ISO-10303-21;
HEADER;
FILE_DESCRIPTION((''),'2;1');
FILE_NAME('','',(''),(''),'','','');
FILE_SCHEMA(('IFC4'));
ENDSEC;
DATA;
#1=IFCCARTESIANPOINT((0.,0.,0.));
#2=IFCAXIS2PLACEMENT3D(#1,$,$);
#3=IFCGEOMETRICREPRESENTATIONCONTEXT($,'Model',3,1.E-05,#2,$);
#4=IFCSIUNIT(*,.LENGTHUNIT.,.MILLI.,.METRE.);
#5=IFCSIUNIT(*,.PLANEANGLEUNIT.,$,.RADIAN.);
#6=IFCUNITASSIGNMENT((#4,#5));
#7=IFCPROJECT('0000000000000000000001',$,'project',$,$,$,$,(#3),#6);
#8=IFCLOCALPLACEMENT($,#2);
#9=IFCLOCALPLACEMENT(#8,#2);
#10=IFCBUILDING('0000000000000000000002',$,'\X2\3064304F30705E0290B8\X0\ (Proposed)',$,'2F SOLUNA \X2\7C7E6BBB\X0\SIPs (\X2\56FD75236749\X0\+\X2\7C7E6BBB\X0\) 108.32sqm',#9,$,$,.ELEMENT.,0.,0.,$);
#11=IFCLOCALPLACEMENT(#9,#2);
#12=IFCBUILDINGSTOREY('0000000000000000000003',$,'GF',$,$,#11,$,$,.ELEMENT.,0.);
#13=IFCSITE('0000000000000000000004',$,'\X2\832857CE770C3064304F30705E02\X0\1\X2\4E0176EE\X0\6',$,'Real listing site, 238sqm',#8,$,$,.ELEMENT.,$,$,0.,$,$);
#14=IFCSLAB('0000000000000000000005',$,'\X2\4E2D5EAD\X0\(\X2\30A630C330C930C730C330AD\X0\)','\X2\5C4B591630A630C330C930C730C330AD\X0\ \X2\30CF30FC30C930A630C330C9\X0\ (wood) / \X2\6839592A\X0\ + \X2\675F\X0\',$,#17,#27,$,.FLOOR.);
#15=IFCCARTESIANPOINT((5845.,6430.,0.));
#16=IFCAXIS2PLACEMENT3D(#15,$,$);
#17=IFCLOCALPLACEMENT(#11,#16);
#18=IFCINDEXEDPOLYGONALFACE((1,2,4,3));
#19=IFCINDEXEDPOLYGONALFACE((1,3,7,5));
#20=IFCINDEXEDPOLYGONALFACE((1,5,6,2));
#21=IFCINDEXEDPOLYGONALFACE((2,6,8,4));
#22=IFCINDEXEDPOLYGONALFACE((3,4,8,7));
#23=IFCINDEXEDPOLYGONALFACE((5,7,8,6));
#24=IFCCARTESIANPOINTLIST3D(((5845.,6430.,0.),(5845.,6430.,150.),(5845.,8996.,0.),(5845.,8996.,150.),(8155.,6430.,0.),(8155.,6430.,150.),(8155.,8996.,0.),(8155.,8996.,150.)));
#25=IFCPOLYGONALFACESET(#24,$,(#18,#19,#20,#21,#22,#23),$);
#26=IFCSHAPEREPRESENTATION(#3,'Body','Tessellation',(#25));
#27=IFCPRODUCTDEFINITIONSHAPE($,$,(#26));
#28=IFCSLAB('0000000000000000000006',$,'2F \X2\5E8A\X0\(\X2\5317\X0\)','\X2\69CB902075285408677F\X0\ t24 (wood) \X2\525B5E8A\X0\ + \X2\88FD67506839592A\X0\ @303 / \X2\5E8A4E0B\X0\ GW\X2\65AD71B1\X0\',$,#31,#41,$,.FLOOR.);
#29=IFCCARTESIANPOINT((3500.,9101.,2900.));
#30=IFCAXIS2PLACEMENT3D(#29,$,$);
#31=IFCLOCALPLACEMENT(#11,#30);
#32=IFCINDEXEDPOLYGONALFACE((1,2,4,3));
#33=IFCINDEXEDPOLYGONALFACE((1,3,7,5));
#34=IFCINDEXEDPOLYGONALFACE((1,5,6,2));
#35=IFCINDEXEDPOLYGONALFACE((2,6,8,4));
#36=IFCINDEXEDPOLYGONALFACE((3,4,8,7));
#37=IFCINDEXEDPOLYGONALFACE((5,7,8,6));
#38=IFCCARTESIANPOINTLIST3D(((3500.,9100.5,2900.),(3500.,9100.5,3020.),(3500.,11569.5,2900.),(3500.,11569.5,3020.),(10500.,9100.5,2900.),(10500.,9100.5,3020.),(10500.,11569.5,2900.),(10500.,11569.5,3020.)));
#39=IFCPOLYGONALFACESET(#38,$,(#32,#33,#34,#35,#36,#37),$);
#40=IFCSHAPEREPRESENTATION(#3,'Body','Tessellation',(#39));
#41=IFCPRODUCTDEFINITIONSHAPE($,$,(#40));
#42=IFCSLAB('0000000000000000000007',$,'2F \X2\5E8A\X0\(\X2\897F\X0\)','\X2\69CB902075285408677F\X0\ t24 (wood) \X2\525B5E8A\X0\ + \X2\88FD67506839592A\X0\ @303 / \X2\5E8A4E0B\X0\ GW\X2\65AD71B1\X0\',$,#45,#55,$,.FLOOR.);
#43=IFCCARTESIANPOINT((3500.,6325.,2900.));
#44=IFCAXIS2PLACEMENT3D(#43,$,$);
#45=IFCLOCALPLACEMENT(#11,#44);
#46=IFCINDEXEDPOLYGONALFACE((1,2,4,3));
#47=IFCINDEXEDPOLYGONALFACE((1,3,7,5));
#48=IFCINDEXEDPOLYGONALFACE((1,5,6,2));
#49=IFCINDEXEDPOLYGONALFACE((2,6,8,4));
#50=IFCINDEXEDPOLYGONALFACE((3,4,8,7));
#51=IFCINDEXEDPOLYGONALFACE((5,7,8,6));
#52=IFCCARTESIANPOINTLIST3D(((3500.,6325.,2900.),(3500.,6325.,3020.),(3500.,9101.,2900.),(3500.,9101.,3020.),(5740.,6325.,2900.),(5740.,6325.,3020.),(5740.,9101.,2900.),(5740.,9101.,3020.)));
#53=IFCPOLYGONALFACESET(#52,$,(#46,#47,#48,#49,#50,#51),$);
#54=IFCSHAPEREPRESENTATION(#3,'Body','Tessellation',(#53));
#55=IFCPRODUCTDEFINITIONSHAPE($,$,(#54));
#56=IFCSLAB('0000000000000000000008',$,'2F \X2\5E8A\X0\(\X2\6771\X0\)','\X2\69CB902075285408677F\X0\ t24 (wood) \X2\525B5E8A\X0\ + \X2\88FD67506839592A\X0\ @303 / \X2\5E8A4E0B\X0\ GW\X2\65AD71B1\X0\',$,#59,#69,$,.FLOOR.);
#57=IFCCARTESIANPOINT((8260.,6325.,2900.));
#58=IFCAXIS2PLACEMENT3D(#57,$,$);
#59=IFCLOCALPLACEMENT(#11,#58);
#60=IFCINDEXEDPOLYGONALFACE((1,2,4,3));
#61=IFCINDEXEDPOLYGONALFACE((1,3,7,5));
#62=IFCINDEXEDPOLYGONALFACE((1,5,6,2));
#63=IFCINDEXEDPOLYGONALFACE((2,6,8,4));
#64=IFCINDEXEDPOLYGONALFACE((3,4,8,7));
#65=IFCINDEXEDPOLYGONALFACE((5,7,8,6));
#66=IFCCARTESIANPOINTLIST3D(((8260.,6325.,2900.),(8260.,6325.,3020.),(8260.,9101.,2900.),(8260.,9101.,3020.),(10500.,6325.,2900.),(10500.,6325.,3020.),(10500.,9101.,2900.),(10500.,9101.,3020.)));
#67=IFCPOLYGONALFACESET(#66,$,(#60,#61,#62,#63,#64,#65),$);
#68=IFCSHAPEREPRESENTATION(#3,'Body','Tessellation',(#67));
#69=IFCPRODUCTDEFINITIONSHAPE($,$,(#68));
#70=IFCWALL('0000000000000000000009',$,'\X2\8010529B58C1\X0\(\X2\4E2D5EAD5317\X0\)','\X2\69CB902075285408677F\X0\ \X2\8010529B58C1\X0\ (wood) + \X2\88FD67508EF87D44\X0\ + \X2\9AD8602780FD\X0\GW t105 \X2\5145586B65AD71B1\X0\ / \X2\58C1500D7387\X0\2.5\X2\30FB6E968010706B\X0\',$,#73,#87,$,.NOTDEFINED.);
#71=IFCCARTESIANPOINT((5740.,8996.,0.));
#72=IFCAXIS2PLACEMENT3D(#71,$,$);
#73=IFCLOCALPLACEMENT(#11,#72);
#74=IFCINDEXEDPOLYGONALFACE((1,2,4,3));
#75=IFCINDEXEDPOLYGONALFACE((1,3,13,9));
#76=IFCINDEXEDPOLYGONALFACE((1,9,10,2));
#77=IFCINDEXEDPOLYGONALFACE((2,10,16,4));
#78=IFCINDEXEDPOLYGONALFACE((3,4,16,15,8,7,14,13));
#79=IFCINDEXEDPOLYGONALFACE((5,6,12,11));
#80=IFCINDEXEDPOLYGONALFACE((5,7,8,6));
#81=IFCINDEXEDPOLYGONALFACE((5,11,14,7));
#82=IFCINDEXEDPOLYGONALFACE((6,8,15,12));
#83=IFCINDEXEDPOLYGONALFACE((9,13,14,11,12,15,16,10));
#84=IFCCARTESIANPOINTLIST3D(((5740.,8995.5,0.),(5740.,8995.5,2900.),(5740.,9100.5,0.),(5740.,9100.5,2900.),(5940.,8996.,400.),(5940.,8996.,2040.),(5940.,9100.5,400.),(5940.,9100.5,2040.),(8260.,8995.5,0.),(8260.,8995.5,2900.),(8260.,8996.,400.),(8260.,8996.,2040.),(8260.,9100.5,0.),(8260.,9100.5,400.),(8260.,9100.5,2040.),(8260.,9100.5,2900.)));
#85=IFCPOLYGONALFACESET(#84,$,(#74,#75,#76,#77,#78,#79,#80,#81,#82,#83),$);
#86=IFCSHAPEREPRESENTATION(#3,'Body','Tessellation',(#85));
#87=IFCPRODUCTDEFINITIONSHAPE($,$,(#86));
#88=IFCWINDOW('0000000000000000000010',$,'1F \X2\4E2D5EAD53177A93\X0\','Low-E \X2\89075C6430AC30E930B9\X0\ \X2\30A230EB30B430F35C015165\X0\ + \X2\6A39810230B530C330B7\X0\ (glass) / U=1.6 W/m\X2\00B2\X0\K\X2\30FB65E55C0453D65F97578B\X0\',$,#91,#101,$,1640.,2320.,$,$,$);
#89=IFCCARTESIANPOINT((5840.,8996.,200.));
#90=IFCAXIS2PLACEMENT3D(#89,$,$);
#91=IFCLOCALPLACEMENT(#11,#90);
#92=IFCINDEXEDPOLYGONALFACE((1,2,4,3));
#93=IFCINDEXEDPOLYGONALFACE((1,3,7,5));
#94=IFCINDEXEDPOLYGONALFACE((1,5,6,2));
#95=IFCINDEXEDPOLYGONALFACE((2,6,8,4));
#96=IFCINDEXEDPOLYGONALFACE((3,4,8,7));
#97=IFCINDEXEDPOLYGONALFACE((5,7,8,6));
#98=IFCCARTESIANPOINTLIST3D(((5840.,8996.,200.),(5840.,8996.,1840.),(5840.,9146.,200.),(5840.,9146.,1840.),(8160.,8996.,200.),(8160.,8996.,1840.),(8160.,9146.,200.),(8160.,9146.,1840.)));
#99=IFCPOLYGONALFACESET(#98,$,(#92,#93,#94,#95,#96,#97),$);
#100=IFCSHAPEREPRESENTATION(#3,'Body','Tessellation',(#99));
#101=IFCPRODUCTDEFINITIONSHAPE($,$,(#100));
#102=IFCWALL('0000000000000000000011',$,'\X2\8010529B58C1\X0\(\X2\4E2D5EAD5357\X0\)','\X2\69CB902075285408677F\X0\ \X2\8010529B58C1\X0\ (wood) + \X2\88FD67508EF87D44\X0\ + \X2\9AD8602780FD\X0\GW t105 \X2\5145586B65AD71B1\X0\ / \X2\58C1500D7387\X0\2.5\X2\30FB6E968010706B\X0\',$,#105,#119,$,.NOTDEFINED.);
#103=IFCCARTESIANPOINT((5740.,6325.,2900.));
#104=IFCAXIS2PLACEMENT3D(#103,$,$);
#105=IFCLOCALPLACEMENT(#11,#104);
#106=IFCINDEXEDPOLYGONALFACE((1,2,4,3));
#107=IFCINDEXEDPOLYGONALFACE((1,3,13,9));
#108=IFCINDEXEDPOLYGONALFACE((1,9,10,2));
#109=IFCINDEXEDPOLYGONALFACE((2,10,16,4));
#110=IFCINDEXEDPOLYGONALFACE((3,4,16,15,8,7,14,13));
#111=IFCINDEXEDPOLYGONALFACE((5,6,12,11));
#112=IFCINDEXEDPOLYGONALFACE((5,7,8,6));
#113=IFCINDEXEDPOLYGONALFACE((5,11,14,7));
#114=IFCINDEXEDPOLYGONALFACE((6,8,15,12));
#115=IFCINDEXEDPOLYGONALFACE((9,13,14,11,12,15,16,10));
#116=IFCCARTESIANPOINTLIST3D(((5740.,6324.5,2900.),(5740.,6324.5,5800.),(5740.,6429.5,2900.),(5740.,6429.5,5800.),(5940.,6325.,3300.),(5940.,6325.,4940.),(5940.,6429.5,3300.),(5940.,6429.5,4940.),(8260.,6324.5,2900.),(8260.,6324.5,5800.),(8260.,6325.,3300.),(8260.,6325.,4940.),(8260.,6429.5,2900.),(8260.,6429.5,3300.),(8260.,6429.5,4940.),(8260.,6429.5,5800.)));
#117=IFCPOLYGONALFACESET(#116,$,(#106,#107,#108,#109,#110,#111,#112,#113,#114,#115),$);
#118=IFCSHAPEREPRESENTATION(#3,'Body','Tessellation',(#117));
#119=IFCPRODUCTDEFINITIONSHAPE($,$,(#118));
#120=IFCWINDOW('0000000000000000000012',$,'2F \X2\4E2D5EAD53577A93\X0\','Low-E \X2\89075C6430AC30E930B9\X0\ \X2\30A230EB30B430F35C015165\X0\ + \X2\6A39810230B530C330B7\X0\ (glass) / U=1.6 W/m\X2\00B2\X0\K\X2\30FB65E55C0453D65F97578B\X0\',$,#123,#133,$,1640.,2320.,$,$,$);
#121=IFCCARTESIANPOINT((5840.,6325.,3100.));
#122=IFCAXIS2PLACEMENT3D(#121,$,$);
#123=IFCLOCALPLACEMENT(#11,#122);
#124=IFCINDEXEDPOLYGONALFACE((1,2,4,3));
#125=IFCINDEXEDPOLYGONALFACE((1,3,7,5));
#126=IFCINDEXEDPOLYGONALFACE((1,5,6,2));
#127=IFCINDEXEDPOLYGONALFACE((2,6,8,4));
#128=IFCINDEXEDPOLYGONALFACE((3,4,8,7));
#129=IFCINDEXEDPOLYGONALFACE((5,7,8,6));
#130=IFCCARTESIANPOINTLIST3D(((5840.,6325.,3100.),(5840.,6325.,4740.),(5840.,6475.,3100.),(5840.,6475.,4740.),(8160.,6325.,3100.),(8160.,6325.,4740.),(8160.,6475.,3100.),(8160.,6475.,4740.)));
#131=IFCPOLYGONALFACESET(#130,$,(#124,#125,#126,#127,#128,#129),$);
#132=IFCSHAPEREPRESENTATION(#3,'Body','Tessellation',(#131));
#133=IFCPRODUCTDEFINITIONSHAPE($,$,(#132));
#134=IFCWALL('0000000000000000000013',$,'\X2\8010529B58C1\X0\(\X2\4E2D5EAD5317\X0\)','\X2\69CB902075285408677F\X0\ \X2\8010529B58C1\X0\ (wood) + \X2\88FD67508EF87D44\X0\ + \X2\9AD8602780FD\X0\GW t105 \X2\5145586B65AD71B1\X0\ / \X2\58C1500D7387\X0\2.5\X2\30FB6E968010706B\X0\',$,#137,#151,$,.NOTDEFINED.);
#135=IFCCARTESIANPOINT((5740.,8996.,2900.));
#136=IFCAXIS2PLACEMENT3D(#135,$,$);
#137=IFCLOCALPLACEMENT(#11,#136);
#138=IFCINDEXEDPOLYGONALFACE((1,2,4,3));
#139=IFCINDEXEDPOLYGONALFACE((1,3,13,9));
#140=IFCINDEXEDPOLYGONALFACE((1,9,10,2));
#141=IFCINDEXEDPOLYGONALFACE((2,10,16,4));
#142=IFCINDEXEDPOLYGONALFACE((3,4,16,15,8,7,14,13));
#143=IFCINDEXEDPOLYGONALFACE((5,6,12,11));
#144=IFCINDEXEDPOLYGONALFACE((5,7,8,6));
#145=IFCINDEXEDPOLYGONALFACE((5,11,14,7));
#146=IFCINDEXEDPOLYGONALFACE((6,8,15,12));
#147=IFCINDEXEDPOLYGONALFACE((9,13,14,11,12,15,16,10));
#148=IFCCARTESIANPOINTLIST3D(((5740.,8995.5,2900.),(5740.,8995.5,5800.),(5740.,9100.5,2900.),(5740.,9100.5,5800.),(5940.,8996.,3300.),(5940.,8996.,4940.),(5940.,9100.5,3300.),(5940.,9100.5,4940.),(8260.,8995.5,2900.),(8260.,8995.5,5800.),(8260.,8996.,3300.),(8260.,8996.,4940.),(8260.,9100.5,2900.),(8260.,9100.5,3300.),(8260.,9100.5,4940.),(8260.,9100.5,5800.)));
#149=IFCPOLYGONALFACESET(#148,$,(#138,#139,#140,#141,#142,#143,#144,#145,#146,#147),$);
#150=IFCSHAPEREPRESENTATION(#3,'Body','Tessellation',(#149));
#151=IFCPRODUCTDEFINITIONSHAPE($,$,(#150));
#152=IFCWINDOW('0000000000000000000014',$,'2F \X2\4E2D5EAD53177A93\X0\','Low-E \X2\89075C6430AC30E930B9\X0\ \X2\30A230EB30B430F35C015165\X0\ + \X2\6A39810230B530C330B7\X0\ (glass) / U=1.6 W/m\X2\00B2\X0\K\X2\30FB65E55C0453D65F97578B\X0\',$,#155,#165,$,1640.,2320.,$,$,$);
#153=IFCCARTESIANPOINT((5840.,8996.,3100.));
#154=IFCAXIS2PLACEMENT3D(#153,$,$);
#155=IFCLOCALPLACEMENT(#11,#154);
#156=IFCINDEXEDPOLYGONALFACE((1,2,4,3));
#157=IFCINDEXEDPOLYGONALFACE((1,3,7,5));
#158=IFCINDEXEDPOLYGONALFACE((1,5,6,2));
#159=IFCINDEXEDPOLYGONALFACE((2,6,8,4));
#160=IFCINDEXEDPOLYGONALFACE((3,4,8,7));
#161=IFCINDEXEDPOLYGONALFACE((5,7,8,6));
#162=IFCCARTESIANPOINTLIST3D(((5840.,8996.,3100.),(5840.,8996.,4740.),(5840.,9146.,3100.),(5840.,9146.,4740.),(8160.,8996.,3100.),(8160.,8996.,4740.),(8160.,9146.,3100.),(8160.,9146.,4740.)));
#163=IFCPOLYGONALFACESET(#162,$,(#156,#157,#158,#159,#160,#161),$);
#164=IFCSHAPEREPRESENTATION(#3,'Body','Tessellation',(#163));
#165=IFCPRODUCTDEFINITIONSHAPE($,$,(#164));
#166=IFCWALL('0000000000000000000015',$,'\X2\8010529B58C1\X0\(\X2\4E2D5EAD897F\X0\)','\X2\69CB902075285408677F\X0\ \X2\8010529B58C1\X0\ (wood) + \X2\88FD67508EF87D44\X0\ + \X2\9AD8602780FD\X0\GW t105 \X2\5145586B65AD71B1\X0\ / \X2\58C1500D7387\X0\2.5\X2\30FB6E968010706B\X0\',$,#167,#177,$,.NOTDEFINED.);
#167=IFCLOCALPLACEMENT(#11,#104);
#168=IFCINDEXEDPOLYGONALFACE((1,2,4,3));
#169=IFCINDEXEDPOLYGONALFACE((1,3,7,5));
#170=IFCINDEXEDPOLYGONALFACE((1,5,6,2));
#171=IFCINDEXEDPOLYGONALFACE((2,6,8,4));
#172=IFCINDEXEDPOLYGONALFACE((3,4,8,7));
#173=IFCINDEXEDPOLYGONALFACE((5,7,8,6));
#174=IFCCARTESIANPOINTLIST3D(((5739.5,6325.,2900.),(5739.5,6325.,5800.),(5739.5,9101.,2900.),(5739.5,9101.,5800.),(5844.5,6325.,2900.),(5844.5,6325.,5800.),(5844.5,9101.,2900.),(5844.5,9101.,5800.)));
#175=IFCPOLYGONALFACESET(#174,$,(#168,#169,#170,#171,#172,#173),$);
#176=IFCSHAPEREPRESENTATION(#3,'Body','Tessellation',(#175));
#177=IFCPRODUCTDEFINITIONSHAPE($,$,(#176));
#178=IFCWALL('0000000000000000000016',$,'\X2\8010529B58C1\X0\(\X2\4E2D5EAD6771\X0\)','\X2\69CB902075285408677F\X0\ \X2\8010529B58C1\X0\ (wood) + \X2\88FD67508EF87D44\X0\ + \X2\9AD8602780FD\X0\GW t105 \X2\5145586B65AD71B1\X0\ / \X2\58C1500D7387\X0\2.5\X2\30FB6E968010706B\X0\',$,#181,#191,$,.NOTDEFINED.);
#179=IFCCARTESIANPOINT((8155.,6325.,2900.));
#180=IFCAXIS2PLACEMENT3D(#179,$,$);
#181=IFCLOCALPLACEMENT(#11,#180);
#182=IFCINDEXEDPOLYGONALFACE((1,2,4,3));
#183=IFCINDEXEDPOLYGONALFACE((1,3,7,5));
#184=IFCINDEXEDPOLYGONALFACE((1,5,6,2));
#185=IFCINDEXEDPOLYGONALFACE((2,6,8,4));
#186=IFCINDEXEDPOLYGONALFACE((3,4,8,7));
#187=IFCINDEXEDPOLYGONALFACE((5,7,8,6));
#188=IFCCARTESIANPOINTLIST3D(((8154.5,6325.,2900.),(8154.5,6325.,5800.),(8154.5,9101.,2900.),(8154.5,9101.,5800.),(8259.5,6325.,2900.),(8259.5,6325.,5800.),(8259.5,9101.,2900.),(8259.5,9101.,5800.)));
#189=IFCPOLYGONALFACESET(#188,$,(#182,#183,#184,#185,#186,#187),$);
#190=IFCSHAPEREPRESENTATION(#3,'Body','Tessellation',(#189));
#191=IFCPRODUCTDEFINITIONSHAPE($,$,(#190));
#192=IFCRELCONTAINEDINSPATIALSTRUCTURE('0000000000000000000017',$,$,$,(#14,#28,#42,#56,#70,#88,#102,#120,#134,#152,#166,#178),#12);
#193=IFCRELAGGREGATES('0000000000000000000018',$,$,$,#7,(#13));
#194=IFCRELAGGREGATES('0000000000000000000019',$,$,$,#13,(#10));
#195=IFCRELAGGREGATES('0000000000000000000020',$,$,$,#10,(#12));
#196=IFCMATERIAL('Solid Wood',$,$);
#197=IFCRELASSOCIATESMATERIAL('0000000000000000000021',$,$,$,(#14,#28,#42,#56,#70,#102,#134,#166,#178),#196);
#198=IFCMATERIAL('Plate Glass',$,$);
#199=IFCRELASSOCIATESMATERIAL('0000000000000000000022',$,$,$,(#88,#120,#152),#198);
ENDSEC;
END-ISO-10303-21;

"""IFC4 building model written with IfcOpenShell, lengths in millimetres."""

from ifc_helpers import new_model, si_unit, frame, frame_2d, origin, place, context, project, spatial, rectangle, extrude, material, element, fill, save


model = new_model("IFC4")

# Units and contexts
model_context = context("Model", 3, precision=1e-05, world=origin())
ifc_project = project(units=[si_unit("LENGTHUNIT", "METRE", prefix="MILLI"), si_unit("PLANEANGLEUNIT", "RADIAN")], contexts=[model_context])

# Site, building, storey
site_placement = place(None, origin())
site = spatial("IfcSite", under=ifc_project, at=site_placement, Name="茨城県つくば市1丁目6", ObjectType="Real listing site, 238sqm", CompositionType="ELEMENT", RefElevation=0.0)
building_placement = place(site_placement, origin())
building = spatial("IfcBuilding", under=site, at=building_placement, Name="つくば市邸 (Proposed)", ObjectType="2F SOLUNA 籾殻SIPs (国産杉+籾殻) 108.32sqm", CompositionType="ELEMENT", ElevationOfRefHeight=0.0, ElevationOfTerrain=0.0)
storey_placement = place(building_placement, origin())
storey = spatial("IfcBuildingStorey", under=building, at=storey_placement, Name="GF", CompositionType="ELEMENT", Elevation=0.0)

# Slabs
ifc_material_1 = material(Name="Solid Wood")
slab_1_placement = place(storey_placement, frame((5845.0, 6430.0, 0.0)))
element("IfcSlab", 1, at=slab_1_placement, inside=storey, material=ifc_material_1, Name="中庭(ウッドデッキ)", Description="屋外ウッドデッキ ハードウッド (wood) / 根太 + 束", PredefinedType="FLOOR", context=model_context, shape_type="SweptSolid", body=[
    extrude(rectangle(XDim=2310.0, YDim=2566.0, at=frame_2d((1155.0, 1283.0))), frame((5845.0, 6430.0, 0.0)), (0.0, 0.0, 1.0), 150.0),
])
slab_2_placement = place(storey_placement, frame((3500.0, 9101.0, 2900.0)))
element("IfcSlab", 2, at=slab_2_placement, inside=storey, material=ifc_material_1, Name="2F 床(北)", Description="構造用合板 t24 (wood) 剛床 + 製材根太 @303 / 床下 GW断熱", PredefinedType="FLOOR", context=model_context, shape_type="SweptSolid", body=[
    extrude(rectangle(XDim=7000.0, YDim=2469.0, at=frame_2d((3500.0, 1234.0))), frame((3500.0, 9101.0, 2900.0)), (0.0, 0.0, 1.0), 120.0),
])
slab_3_placement = place(storey_placement, frame((3500.0, 6325.0, 2900.0)))
element("IfcSlab", 3, at=slab_3_placement, inside=storey, material=ifc_material_1, Name="2F 床(西)", Description="構造用合板 t24 (wood) 剛床 + 製材根太 @303 / 床下 GW断熱", PredefinedType="FLOOR", context=model_context, shape_type="SweptSolid", body=[
    extrude(rectangle(XDim=2240.0, YDim=2776.0, at=frame_2d((1120.0, 1388.0))), frame((3500.0, 6325.0, 2900.0)), (0.0, 0.0, 1.0), 120.0),
])
slab_4_placement = place(storey_placement, frame((8260.0, 6325.0, 2900.0)))
element("IfcSlab", 4, at=slab_4_placement, inside=storey, material=ifc_material_1, Name="2F 床(東)", Description="構造用合板 t24 (wood) 剛床 + 製材根太 @303 / 床下 GW断熱", PredefinedType="FLOOR", context=model_context, shape_type="SweptSolid", body=[
    extrude(rectangle(XDim=2240.0, YDim=2776.0, at=frame_2d((1120.0, 1388.0))), frame((8260.0, 6325.0, 2900.0)), (0.0, 0.0, 1.0), 120.0),
])

# Wall, opening, window
wall_1_placement = place(storey_placement, frame((5740.0, 8996.0, 0.0)))
wall_1 = element("IfcWall", 5, at=wall_1_placement, inside=storey, material=ifc_material_1, Name="耐力壁(中庭北)", Description="構造用合板 耐力壁 (wood) + 製材軸組 + 高性能GW t105 充填断熱 / 壁倍率2.5・準耐火", PredefinedType="NOTDEFINED", context=model_context, shape_type="SweptSolid", body=[
    extrude(rectangle(XDim=2520.0, YDim=105.0, at=frame_2d((1260.0, 52.0))), frame((5740.0, 8996.0, 0.0)), (0.0, 0.0, 1.0), 2900.0),
])
opening_1_placement = place(storey_placement, frame((5840.0, 8996.0, 200.0)))
opening_1 = element("IfcOpeningElement", 6, at=opening_1_placement, cuts=wall_1, PredefinedType="NOTDEFINED", context=model_context, shape_type="SweptSolid", body=[
    extrude(rectangle(XDim=2320.0, YDim=150.0, at=frame_2d((1160.0, 75.0))), frame((5840.0, 8996.0, 200.0)), (0.0, 0.0, 1.0), 1640.0),
])
ifc_material_2 = material(Name="Plate Glass")
window_1_placement = place(storey_placement, frame((5840.0, 8996.0, 200.0)))
window_1 = element("IfcWindow", 7, at=window_1_placement, inside=storey, material=ifc_material_2, Name="1F 中庭北窓", Description="Low-E 複層ガラス アルゴン封入 + 樹脂サッシ (glass) / U=1.6 W/m²K・日射取得型", OverallHeight=1640.0, OverallWidth=2320.0, context=model_context, shape_type="SweptSolid", body=[
    extrude(rectangle(XDim=2320.0, YDim=150.0, at=frame_2d((1160.0, 75.0))), frame((5840.0, 8996.0, 200.0)), (0.0, 0.0, 1.0), 1640.0),
])
fill(opening_1, window_1)

# Walls, openings, windows
wall_2_placement = place(storey_placement, frame((5740.0, 6325.0, 2900.0)))
wall_2 = element("IfcWall", 8, at=wall_2_placement, inside=storey, material=ifc_material_1, Name="耐力壁(中庭南)", Description="構造用合板 耐力壁 (wood) + 製材軸組 + 高性能GW t105 充填断熱 / 壁倍率2.5・準耐火", PredefinedType="NOTDEFINED", context=model_context, shape_type="SweptSolid", body=[
    extrude(rectangle(XDim=2520.0, YDim=105.0, at=frame_2d((1260.0, 52.0))), frame((5740.0, 6325.0, 2900.0)), (0.0, 0.0, 1.0), 2900.0),
])
opening_2_placement = place(storey_placement, frame((5840.0, 6325.0, 3100.0)))
opening_2 = element("IfcOpeningElement", 9, at=opening_2_placement, cuts=wall_2, PredefinedType="NOTDEFINED", context=model_context, shape_type="SweptSolid", body=[
    extrude(rectangle(XDim=2320.0, YDim=150.0, at=frame_2d((1160.0, 75.0))), frame((5840.0, 6325.0, 3100.0)), (0.0, 0.0, 1.0), 1640.0),
])
window_2_placement = place(storey_placement, frame((5840.0, 6325.0, 3100.0)))
window_2 = element("IfcWindow", 10, at=window_2_placement, inside=storey, material=ifc_material_2, Name="2F 中庭南窓", Description="Low-E 複層ガラス アルゴン封入 + 樹脂サッシ (glass) / U=1.6 W/m²K・日射取得型", OverallHeight=1640.0, OverallWidth=2320.0, context=model_context, shape_type="SweptSolid", body=[
    extrude(rectangle(XDim=2320.0, YDim=150.0, at=frame_2d((1160.0, 75.0))), frame((5840.0, 6325.0, 3100.0)), (0.0, 0.0, 1.0), 1640.0),
])
fill(opening_2, window_2)
wall_3_placement = place(storey_placement, frame((5740.0, 8996.0, 2900.0)))
wall_3 = element("IfcWall", 11, at=wall_3_placement, inside=storey, material=ifc_material_1, Name="耐力壁(中庭北)", Description="構造用合板 耐力壁 (wood) + 製材軸組 + 高性能GW t105 充填断熱 / 壁倍率2.5・準耐火", PredefinedType="NOTDEFINED", context=model_context, shape_type="SweptSolid", body=[
    extrude(rectangle(XDim=2520.0, YDim=105.0, at=frame_2d((1260.0, 52.0))), frame((5740.0, 8996.0, 2900.0)), (0.0, 0.0, 1.0), 2900.0),
])
opening_3_placement = place(storey_placement, frame((5840.0, 8996.0, 3100.0)))
opening_3 = element("IfcOpeningElement", 12, at=opening_3_placement, cuts=wall_3, PredefinedType="NOTDEFINED", context=model_context, shape_type="SweptSolid", body=[
    extrude(rectangle(XDim=2320.0, YDim=150.0, at=frame_2d((1160.0, 75.0))), frame((5840.0, 8996.0, 3100.0)), (0.0, 0.0, 1.0), 1640.0),
])
window_3_placement = place(storey_placement, frame((5840.0, 8996.0, 3100.0)))
window_3 = element("IfcWindow", 13, at=window_3_placement, inside=storey, material=ifc_material_2, Name="2F 中庭北窓", Description="Low-E 複層ガラス アルゴン封入 + 樹脂サッシ (glass) / U=1.6 W/m²K・日射取得型", OverallHeight=1640.0, OverallWidth=2320.0, context=model_context, shape_type="SweptSolid", body=[
    extrude(rectangle(XDim=2320.0, YDim=150.0, at=frame_2d((1160.0, 75.0))), frame((5840.0, 8996.0, 3100.0)), (0.0, 0.0, 1.0), 1640.0),
])
fill(opening_3, window_3)

# Walls
wall_4_placement = place(storey_placement, frame((5740.0, 6325.0, 2900.0)))
element("IfcWall", 14, at=wall_4_placement, inside=storey, material=ifc_material_1, Name="耐力壁(中庭西)", Description="構造用合板 耐力壁 (wood) + 製材軸組 + 高性能GW t105 充填断熱 / 壁倍率2.5・準耐火", PredefinedType="NOTDEFINED", context=model_context, shape_type="SweptSolid", body=[
    extrude(rectangle(XDim=105.0, YDim=2776.0, at=frame_2d((52.0, 1388.0))), frame((5740.0, 6325.0, 2900.0)), (0.0, 0.0, 1.0), 2900.0),
])
wall_5_placement = place(storey_placement, frame((8155.0, 6325.0, 2900.0)))
element("IfcWall", 15, at=wall_5_placement, inside=storey, material=ifc_material_1, Name="耐力壁(中庭東)", Description="構造用合板 耐力壁 (wood) + 製材軸組 + 高性能GW t105 充填断熱 / 壁倍率2.5・準耐火", PredefinedType="NOTDEFINED", context=model_context, shape_type="SweptSolid", body=[
    extrude(rectangle(XDim=105.0, YDim=2776.0, at=frame_2d((52.0, 1388.0))), frame((8155.0, 6325.0, 2900.0)), (0.0, 0.0, 1.0), 2900.0),
])

save(model, "model.ifc")
